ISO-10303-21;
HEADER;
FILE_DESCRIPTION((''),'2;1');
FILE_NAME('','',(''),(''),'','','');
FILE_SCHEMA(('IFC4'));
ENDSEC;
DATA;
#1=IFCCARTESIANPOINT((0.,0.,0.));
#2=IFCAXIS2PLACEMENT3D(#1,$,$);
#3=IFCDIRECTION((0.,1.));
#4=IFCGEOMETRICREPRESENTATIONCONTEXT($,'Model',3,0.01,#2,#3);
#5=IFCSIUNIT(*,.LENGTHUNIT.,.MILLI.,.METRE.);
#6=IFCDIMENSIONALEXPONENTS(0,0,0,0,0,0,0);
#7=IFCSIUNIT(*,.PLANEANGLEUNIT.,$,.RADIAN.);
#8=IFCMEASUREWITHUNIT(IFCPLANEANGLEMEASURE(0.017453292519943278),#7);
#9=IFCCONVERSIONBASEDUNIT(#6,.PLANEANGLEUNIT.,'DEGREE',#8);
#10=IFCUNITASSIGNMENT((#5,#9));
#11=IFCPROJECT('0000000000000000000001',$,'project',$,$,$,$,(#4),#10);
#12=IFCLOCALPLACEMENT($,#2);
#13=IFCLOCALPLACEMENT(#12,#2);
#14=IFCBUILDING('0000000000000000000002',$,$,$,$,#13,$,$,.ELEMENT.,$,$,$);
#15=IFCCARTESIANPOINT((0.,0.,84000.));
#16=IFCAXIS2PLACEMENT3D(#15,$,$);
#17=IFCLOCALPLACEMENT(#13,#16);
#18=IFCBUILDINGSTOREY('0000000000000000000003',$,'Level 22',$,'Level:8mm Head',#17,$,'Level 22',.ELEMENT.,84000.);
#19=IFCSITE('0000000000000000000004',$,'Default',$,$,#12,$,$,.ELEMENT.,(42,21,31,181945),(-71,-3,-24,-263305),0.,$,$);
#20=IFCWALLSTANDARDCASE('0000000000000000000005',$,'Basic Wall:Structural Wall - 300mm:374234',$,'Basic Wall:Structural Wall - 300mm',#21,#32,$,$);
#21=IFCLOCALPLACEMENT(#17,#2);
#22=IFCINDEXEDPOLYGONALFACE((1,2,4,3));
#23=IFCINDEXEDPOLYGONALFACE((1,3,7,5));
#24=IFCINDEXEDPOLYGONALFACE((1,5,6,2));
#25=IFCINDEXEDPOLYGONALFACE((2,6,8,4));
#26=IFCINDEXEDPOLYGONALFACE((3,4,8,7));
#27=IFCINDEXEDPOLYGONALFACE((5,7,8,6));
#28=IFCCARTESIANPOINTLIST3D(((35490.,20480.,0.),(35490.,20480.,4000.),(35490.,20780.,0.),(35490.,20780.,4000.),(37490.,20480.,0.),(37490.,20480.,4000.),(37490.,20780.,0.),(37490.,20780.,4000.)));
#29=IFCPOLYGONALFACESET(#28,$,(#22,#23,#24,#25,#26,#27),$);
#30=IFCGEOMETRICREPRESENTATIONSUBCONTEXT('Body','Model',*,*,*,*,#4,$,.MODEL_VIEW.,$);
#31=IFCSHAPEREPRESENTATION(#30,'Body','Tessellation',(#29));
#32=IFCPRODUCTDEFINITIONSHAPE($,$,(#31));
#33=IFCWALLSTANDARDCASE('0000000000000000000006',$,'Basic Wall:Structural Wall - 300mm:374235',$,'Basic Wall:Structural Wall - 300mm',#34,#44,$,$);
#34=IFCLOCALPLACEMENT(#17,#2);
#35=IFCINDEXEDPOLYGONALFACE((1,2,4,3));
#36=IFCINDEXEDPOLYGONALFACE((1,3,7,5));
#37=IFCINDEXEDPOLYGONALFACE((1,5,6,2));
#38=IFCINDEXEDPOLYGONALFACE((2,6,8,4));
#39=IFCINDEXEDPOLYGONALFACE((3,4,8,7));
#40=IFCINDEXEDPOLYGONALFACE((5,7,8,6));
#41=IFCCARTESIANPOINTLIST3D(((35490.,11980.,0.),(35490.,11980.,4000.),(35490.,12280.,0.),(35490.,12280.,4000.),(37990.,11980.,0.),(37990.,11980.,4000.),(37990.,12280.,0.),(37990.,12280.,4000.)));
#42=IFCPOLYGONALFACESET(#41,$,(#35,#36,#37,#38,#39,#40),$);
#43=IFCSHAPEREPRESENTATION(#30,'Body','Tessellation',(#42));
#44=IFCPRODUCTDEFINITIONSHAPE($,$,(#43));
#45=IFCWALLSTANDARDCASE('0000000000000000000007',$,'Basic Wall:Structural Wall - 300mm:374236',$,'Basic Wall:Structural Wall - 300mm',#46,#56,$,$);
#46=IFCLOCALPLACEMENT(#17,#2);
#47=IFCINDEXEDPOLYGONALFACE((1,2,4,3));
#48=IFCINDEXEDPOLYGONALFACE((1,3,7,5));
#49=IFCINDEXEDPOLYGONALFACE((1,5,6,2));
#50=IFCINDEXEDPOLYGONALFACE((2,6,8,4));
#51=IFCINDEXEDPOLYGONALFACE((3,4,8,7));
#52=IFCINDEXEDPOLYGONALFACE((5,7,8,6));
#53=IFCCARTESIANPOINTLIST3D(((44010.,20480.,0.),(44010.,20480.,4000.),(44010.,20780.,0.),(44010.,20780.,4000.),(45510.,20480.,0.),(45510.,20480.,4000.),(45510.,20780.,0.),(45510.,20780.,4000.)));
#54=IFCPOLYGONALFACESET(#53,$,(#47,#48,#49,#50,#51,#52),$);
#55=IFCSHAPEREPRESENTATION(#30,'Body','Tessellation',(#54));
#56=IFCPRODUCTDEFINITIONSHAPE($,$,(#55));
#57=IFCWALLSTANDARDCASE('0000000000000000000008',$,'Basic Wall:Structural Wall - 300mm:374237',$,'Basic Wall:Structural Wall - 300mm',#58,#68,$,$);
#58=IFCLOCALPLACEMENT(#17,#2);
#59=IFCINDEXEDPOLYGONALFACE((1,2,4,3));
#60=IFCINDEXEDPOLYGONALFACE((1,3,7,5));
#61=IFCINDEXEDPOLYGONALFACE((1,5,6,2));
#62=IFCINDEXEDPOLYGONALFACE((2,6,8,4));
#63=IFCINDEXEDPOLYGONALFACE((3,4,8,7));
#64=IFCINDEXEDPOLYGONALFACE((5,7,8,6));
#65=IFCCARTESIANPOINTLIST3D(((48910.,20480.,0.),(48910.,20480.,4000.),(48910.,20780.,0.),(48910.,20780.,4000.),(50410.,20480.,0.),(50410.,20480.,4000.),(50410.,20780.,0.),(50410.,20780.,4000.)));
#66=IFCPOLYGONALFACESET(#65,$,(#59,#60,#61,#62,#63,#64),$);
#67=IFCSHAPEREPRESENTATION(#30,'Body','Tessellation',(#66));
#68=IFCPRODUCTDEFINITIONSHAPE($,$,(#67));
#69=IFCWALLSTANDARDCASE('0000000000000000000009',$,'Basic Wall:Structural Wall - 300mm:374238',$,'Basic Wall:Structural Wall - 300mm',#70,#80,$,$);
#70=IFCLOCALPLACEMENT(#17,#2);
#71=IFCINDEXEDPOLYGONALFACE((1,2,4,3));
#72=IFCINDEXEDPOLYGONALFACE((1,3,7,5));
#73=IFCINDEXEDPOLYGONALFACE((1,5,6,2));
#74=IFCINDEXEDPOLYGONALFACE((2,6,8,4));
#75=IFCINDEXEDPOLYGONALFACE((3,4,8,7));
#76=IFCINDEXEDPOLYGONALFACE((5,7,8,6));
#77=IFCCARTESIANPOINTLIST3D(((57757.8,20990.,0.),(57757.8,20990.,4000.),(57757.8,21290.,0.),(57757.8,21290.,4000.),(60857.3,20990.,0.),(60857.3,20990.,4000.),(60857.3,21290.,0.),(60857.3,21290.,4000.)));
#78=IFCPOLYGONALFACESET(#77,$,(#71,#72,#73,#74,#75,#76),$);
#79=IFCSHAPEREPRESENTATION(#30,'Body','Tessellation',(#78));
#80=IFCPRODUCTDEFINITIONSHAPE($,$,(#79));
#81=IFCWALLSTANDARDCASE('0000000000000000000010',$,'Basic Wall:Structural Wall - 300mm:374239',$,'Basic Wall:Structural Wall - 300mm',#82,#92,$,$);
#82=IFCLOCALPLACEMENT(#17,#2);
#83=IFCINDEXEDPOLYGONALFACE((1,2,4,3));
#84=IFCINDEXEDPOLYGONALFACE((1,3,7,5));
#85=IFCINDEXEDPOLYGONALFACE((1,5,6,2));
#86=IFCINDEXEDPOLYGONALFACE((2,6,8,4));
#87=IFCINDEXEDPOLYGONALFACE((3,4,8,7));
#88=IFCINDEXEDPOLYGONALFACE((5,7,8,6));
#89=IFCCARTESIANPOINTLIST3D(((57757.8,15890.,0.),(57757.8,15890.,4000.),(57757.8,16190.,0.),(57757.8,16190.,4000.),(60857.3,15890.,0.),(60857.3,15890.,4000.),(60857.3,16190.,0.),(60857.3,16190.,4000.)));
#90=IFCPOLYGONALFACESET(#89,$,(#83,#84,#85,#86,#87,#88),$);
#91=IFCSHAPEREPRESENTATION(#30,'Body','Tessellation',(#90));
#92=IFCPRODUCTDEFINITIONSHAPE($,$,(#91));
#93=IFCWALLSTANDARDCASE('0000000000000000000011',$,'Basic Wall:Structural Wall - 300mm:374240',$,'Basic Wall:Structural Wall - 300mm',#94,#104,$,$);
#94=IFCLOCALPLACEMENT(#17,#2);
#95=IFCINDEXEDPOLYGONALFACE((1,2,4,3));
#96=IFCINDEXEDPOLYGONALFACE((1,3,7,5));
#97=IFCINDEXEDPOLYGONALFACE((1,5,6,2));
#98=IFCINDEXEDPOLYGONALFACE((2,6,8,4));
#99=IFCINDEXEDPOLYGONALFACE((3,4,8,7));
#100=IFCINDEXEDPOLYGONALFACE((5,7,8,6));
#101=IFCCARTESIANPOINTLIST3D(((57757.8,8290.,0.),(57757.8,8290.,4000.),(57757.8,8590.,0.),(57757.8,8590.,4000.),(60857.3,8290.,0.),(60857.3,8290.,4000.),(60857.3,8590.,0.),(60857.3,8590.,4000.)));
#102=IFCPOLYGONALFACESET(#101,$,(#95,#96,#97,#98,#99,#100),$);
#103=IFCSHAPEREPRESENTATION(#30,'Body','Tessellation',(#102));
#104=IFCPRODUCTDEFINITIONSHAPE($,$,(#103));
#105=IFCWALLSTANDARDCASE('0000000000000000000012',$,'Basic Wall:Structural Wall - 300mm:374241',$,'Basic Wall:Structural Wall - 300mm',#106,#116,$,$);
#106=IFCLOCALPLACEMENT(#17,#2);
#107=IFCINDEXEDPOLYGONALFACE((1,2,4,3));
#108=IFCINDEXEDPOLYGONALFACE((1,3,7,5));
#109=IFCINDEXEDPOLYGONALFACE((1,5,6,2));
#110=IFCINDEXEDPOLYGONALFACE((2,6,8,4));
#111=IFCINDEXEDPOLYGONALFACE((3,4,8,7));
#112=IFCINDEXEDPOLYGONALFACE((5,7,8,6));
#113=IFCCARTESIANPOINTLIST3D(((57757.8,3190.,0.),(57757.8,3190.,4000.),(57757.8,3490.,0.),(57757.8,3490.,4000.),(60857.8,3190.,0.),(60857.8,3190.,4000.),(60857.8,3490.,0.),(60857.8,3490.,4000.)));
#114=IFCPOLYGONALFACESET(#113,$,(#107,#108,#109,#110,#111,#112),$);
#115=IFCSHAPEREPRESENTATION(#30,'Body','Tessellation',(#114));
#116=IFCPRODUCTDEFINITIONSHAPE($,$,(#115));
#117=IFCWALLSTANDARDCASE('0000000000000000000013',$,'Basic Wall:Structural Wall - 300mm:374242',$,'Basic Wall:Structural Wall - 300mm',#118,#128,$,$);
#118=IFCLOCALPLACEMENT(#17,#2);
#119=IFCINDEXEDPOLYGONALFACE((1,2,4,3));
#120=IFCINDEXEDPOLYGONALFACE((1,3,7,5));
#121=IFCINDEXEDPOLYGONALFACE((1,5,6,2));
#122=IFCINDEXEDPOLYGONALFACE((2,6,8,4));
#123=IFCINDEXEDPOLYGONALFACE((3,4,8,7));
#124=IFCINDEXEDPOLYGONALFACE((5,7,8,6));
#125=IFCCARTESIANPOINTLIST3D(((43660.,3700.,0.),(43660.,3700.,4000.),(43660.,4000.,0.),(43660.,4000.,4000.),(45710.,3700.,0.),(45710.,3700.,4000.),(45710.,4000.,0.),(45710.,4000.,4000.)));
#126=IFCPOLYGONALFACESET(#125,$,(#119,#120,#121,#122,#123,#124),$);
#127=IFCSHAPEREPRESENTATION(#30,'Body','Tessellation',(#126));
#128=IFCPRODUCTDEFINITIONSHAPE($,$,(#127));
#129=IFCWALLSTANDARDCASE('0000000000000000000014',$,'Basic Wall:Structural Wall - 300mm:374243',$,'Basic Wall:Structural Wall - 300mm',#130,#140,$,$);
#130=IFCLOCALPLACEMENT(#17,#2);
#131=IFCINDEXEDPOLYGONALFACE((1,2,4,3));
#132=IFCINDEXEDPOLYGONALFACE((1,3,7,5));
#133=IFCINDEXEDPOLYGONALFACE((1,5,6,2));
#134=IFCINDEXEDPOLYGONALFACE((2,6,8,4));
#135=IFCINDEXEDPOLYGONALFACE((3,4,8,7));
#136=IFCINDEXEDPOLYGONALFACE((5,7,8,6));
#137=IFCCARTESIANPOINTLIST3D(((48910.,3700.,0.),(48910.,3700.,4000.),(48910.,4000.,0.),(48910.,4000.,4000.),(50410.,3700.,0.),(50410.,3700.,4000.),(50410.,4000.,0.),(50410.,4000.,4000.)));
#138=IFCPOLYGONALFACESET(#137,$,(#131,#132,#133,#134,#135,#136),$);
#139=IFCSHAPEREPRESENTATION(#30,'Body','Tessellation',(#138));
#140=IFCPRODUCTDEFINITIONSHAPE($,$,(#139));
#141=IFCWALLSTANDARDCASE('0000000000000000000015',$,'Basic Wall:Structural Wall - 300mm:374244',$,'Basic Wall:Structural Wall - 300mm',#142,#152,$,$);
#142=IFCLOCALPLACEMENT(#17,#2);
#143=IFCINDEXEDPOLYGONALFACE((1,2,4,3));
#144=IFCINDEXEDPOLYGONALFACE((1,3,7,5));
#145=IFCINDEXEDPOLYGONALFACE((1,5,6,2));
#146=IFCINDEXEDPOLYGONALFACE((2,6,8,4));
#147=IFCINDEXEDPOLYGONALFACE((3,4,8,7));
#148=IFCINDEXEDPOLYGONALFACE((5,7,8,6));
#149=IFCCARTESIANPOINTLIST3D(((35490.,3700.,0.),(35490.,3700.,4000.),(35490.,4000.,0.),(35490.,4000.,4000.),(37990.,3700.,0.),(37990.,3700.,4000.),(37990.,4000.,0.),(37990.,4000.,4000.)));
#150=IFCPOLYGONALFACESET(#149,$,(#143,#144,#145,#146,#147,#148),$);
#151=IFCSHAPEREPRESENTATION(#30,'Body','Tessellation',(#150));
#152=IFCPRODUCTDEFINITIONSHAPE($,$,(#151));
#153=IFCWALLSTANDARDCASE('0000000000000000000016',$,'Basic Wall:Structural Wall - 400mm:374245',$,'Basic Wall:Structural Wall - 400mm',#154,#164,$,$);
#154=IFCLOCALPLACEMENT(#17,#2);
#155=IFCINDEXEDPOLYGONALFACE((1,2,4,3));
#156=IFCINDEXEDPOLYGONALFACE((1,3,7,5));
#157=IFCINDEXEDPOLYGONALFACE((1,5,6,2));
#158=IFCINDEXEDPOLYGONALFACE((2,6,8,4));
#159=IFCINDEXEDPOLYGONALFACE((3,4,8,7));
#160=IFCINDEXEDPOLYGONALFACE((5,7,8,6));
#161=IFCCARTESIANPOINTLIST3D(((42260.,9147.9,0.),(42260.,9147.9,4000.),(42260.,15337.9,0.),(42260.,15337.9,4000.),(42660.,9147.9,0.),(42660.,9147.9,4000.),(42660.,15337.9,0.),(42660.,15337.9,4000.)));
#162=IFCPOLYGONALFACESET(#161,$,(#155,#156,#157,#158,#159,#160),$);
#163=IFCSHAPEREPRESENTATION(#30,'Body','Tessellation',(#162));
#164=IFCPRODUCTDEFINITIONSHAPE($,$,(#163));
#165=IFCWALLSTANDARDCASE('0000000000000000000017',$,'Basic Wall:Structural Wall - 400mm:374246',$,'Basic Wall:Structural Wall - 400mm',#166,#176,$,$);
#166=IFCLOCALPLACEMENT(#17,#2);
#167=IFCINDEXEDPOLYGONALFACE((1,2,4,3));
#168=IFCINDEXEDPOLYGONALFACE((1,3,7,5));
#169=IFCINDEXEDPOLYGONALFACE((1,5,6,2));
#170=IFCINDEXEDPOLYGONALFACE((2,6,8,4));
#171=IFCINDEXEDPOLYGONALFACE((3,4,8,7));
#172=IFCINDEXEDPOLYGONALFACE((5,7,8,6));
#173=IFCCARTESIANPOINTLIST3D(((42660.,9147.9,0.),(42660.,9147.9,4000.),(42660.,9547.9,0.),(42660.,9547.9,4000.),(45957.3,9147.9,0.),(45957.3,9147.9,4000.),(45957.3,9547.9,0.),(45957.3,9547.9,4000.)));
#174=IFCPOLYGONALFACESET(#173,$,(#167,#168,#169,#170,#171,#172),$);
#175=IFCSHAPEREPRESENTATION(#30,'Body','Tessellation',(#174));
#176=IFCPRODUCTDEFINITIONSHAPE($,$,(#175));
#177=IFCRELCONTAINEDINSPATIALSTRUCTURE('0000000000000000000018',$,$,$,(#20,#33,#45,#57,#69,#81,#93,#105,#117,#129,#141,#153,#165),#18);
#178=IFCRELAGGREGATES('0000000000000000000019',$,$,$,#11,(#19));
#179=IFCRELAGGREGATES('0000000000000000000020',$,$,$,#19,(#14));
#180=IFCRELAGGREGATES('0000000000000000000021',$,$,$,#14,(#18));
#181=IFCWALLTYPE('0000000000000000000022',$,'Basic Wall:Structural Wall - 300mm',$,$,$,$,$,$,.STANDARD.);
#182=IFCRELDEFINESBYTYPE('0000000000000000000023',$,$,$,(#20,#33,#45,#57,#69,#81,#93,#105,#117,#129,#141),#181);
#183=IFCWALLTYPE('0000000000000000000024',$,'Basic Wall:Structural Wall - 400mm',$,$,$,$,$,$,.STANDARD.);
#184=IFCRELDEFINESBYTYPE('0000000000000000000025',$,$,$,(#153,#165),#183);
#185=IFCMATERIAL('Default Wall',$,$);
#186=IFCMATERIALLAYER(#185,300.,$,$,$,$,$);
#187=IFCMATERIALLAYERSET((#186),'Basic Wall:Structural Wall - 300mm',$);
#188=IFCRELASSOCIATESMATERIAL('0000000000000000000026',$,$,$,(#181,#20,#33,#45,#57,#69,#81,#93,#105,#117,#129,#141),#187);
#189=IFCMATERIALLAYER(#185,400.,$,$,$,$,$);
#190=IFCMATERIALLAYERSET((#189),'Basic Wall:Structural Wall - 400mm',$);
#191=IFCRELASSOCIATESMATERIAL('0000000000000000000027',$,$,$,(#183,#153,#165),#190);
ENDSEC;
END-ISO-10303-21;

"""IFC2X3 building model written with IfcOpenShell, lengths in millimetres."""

from ifc_helpers import new_model, entity, si_unit, converted_unit, direction, frame, frame_2d, origin, place, context, subcontext, project, spatial, rectangle, extrude, material, layer, layer_set, layer_usage, type_object, element, save


model = new_model("IFC2X3")

# Units and contexts
model_context = context("Model", 3, precision=0.01, world=origin(), true_north=direction((0.0, 1.0)))
body_context = subcontext(model_context, "Body", "Model", "MODEL_VIEW")
ifc_project = project(units=[si_unit("LENGTHUNIT", "METRE", prefix="MILLI"), converted_unit("PLANEANGLEUNIT", "DEGREE", entity("IfcPlaneAngleMeasure", 0.017453292519943278), si_unit("PLANEANGLEUNIT", "RADIAN"), dimensions=[0, 0, 0, 0, 0, 0, 0])], contexts=[model_context])

# Site, building, storey
site_placement = place(None, origin())
site = spatial("IfcSite", under=ifc_project, at=site_placement, Name="Default", CompositionType="ELEMENT", RefLatitude=(42, 21, 31, 181945), RefLongitude=(-71, -3, -24, -263305), RefElevation=0.0)
building_placement = place(site_placement, origin())
building = spatial("IfcBuilding", under=site, at=building_placement, CompositionType="ELEMENT")
storey_placement = place(building_placement, frame((0.0, 0.0, 84000.0)))
storey = spatial("IfcBuildingStorey", under=building, at=storey_placement, Name="Level 22", ObjectType="Level:8mm Head", LongName="Level 22", CompositionType="ELEMENT", Elevation=84000.0)

# Walls
ifc_material_1 = material(Name="Default Wall")
ifc_layer_1 = layer(ifc_material_1, 300.0)
ifc_layer_set_1 = layer_set([ifc_layer_1], Name="Basic Wall:Structural Wall - 300mm")
ifc_layer_usage_1 = layer_usage(ifc_layer_set_1, "AXIS2", "NEGATIVE", 150.0)
wall_type_1 = type_object("IfcWallType", Name="Basic Wall:Structural Wall - 300mm", PredefinedType="STANDARD", material=ifc_layer_set_1)
wall_1_placement = place(storey_placement, frame((35490.0, 20630.0, 0.0)))
element("IfcWallStandardCase", 1, at=wall_1_placement, inside=storey, type_object=wall_type_1, material=ifc_layer_usage_1, Name="Basic Wall:Structural Wall - 300mm:374234", ObjectType="Basic Wall:Structural Wall - 300mm", context=body_context, shape_type="SweptSolid", body=[
    extrude(rectangle(XDim=2000.0, YDim=300.0, at=frame_2d((1000.0, 0.0), x_axis=(-1.0, 0.0))), origin(), (0.0, 0.0, 1.0), 4000.0),
])
ifc_layer_usage_2 = layer_usage(ifc_layer_set_1, "AXIS2", "POSITIVE", -150.0)
wall_2_placement = place(storey_placement, frame((35490.0, 12130.0, 0.0)))
element("IfcWallStandardCase", 2, at=wall_2_placement, inside=storey, type_object=wall_type_1, material=ifc_layer_usage_2, Name="Basic Wall:Structural Wall - 300mm:374235", ObjectType="Basic Wall:Structural Wall - 300mm", context=body_context, shape_type="SweptSolid", body=[
    extrude(rectangle(XDim=2500.0, YDim=300.0, at=frame_2d((1250.0, 0.0), x_axis=(-1.0, 0.0))), origin(), (0.0, 0.0, 1.0), 4000.0),
])
ifc_layer_usage_3 = layer_usage(ifc_layer_set_1, "AXIS2", "NEGATIVE", 150.0)
wall_3_placement = place(storey_placement, frame((44010.0, 20630.0, 0.0)))
element("IfcWallStandardCase", 3, at=wall_3_placement, inside=storey, type_object=wall_type_1, material=ifc_layer_usage_3, Name="Basic Wall:Structural Wall - 300mm:374236", ObjectType="Basic Wall:Structural Wall - 300mm", context=body_context, shape_type="SweptSolid", body=[
    extrude(rectangle(XDim=1500.0, YDim=300.0, at=frame_2d((750.0, 0.0), x_axis=(-1.0, 0.0))), origin(), (0.0, 0.0, 1.0), 4000.0),
])
ifc_layer_usage_4 = layer_usage(ifc_layer_set_1, "AXIS2", "NEGATIVE", 150.0)
wall_4_placement = place(storey_placement, frame((48910.0, 20630.0, 0.0)))
element("IfcWallStandardCase", 4, at=wall_4_placement, inside=storey, type_object=wall_type_1, material=ifc_layer_usage_4, Name="Basic Wall:Structural Wall - 300mm:374237", ObjectType="Basic Wall:Structural Wall - 300mm", context=body_context, shape_type="SweptSolid", body=[
    extrude(rectangle(XDim=1500.0, YDim=300.0, at=frame_2d((750.0, 0.0), x_axis=(-1.0, 0.0))), origin(), (0.0, 0.0, 1.0), 4000.0),
])
ifc_layer_usage_5 = layer_usage(ifc_layer_set_1, "AXIS2", "NEGATIVE", 150.0)
wall_5_placement = place(storey_placement, frame((57757.8, 21140.0, 0.0)))
element("IfcWallStandardCase", 5, at=wall_5_placement, inside=storey, type_object=wall_type_1, material=ifc_layer_usage_5, Name="Basic Wall:Structural Wall - 300mm:374238", ObjectType="Basic Wall:Structural Wall - 300mm", context=body_context, shape_type="SweptSolid", body=[
    extrude(rectangle(XDim=3099.5, YDim=300.0, at=frame_2d((1549.8, 0.0), x_axis=(-1.0, 0.0))), origin(), (0.0, 0.0, 1.0), 4000.0),
])
ifc_layer_usage_6 = layer_usage(ifc_layer_set_1, "AXIS2", "NEGATIVE", 150.0)
wall_6_placement = place(storey_placement, frame((57757.8, 16040.0, 0.0)))
element("IfcWallStandardCase", 6, at=wall_6_placement, inside=storey, type_object=wall_type_1, material=ifc_layer_usage_6, Name="Basic Wall:Structural Wall - 300mm:374239", ObjectType="Basic Wall:Structural Wall - 300mm", context=body_context, shape_type="SweptSolid", body=[
    extrude(rectangle(XDim=3099.5, YDim=300.0, at=frame_2d((1549.8, 0.0), x_axis=(-1.0, 0.0))), origin(), (0.0, 0.0, 1.0), 4000.0),
])
ifc_layer_usage_7 = layer_usage(ifc_layer_set_1, "AXIS2", "POSITIVE", -150.0)
wall_7_placement = place(storey_placement, frame((57757.8, 8440.0, 0.0)))
element("IfcWallStandardCase", 7, at=wall_7_placement, inside=storey, type_object=wall_type_1, material=ifc_layer_usage_7, Name="Basic Wall:Structural Wall - 300mm:374240", ObjectType="Basic Wall:Structural Wall - 300mm", context=body_context, shape_type="SweptSolid", body=[
    extrude(rectangle(XDim=3099.5, YDim=300.0, at=frame_2d((1549.8, 0.0), x_axis=(-1.0, 0.0))), origin(), (0.0, 0.0, 1.0), 4000.0),
])
ifc_layer_usage_8 = layer_usage(ifc_layer_set_1, "AXIS2", "POSITIVE", -150.0)
wall_8_placement = place(storey_placement, frame((57757.8, 3340.0, 0.0)))
element("IfcWallStandardCase", 8, at=wall_8_placement, inside=storey, type_object=wall_type_1, material=ifc_layer_usage_8, Name="Basic Wall:Structural Wall - 300mm:374241", ObjectType="Basic Wall:Structural Wall - 300mm", context=body_context, shape_type="SweptSolid", body=[
    extrude(rectangle(XDim=3100.0, YDim=300.0, at=frame_2d((1550.0, 0.0), x_axis=(-1.0, 0.0))), origin(), (0.0, 0.0, 1.0), 4000.0),
])
ifc_layer_usage_9 = layer_usage(ifc_layer_set_1, "AXIS2", "POSITIVE", -150.0)
wall_9_placement = place(storey_placement, frame((43660.0, 3850.0, 0.0)))
element("IfcWallStandardCase", 9, at=wall_9_placement, inside=storey, type_object=wall_type_1, material=ifc_layer_usage_9, Name="Basic Wall:Structural Wall - 300mm:374242", ObjectType="Basic Wall:Structural Wall - 300mm", context=body_context, shape_type="SweptSolid", body=[
    extrude(rectangle(XDim=2050.0, YDim=300.0, at=frame_2d((1025.0, 0.0), x_axis=(-1.0, 0.0))), origin(), (0.0, 0.0, 1.0), 4000.0),
])
ifc_layer_usage_10 = layer_usage(ifc_layer_set_1, "AXIS2", "POSITIVE", -150.0)
wall_10_placement = place(storey_placement, frame((48910.0, 3850.0, 0.0)))
element("IfcWallStandardCase", 10, at=wall_10_placement, inside=storey, type_object=wall_type_1, material=ifc_layer_usage_10, Name="Basic Wall:Structural Wall - 300mm:374243", ObjectType="Basic Wall:Structural Wall - 300mm", context=body_context, shape_type="SweptSolid", body=[
    extrude(rectangle(XDim=1500.0, YDim=300.0, at=frame_2d((750.0, 0.0), x_axis=(-1.0, 0.0))), origin(), (0.0, 0.0, 1.0), 4000.0),
])
ifc_layer_usage_11 = layer_usage(ifc_layer_set_1, "AXIS2", "POSITIVE", -150.0)
wall_11_placement = place(storey_placement, frame((35490.0, 3850.0, 0.0)))
element("IfcWallStandardCase", 11, at=wall_11_placement, inside=storey, type_object=wall_type_1, material=ifc_layer_usage_11, Name="Basic Wall:Structural Wall - 300mm:374244", ObjectType="Basic Wall:Structural Wall - 300mm", context=body_context, shape_type="SweptSolid", body=[
    extrude(rectangle(XDim=2500.0, YDim=300.0, at=frame_2d((1250.0, 0.0), x_axis=(-1.0, 0.0))), origin(), (0.0, 0.0, 1.0), 4000.0),
])
ifc_layer_2 = layer(ifc_material_1, 400.0)
ifc_layer_set_2 = layer_set([ifc_layer_2], Name="Basic Wall:Structural Wall - 400mm")
ifc_layer_usage_12 = layer_usage(ifc_layer_set_2, "AXIS2", "POSITIVE", -200.0)
wall_type_2 = type_object("IfcWallType", Name="Basic Wall:Structural Wall - 400mm", PredefinedType="STANDARD", material=ifc_layer_set_2)
wall_12_placement = place(storey_placement, frame((42460.0, 15337.9, 0.0), z_axis=(0.0, 0.0, 1.0), x_axis=(0.0, -1.0, 0.0)))
element("IfcWallStandardCase", 12, at=wall_12_placement, inside=storey, type_object=wall_type_2, material=ifc_layer_usage_12, Name="Basic Wall:Structural Wall - 400mm:374245", ObjectType="Basic Wall:Structural Wall - 400mm", context=body_context, shape_type="SweptSolid", body=[
    extrude(rectangle(XDim=6190.0, YDim=400.0, at=frame_2d((3095.0, 0.0), x_axis=(-1.0, 0.0))), origin(), (0.0, 0.0, 1.0), 4000.0),
])
ifc_layer_usage_13 = layer_usage(ifc_layer_set_2, "AXIS2", "POSITIVE", -200.0)
wall_13_placement = place(storey_placement, frame((42660.0, 9347.9, 0.0)))
element("IfcWallStandardCase", 13, at=wall_13_placement, inside=storey, type_object=wall_type_2, material=ifc_layer_usage_13, Name="Basic Wall:Structural Wall - 400mm:374246", ObjectType="Basic Wall:Structural Wall - 400mm", context=body_context, shape_type="SweptSolid", body=[
    extrude(rectangle(XDim=3297.3, YDim=400.0, at=frame_2d((1648.6, 0.0), x_axis=(-1.0, 0.0))), origin(), (0.0, 0.0, 1.0), 4000.0),
])

save(model, "model.ifc")
